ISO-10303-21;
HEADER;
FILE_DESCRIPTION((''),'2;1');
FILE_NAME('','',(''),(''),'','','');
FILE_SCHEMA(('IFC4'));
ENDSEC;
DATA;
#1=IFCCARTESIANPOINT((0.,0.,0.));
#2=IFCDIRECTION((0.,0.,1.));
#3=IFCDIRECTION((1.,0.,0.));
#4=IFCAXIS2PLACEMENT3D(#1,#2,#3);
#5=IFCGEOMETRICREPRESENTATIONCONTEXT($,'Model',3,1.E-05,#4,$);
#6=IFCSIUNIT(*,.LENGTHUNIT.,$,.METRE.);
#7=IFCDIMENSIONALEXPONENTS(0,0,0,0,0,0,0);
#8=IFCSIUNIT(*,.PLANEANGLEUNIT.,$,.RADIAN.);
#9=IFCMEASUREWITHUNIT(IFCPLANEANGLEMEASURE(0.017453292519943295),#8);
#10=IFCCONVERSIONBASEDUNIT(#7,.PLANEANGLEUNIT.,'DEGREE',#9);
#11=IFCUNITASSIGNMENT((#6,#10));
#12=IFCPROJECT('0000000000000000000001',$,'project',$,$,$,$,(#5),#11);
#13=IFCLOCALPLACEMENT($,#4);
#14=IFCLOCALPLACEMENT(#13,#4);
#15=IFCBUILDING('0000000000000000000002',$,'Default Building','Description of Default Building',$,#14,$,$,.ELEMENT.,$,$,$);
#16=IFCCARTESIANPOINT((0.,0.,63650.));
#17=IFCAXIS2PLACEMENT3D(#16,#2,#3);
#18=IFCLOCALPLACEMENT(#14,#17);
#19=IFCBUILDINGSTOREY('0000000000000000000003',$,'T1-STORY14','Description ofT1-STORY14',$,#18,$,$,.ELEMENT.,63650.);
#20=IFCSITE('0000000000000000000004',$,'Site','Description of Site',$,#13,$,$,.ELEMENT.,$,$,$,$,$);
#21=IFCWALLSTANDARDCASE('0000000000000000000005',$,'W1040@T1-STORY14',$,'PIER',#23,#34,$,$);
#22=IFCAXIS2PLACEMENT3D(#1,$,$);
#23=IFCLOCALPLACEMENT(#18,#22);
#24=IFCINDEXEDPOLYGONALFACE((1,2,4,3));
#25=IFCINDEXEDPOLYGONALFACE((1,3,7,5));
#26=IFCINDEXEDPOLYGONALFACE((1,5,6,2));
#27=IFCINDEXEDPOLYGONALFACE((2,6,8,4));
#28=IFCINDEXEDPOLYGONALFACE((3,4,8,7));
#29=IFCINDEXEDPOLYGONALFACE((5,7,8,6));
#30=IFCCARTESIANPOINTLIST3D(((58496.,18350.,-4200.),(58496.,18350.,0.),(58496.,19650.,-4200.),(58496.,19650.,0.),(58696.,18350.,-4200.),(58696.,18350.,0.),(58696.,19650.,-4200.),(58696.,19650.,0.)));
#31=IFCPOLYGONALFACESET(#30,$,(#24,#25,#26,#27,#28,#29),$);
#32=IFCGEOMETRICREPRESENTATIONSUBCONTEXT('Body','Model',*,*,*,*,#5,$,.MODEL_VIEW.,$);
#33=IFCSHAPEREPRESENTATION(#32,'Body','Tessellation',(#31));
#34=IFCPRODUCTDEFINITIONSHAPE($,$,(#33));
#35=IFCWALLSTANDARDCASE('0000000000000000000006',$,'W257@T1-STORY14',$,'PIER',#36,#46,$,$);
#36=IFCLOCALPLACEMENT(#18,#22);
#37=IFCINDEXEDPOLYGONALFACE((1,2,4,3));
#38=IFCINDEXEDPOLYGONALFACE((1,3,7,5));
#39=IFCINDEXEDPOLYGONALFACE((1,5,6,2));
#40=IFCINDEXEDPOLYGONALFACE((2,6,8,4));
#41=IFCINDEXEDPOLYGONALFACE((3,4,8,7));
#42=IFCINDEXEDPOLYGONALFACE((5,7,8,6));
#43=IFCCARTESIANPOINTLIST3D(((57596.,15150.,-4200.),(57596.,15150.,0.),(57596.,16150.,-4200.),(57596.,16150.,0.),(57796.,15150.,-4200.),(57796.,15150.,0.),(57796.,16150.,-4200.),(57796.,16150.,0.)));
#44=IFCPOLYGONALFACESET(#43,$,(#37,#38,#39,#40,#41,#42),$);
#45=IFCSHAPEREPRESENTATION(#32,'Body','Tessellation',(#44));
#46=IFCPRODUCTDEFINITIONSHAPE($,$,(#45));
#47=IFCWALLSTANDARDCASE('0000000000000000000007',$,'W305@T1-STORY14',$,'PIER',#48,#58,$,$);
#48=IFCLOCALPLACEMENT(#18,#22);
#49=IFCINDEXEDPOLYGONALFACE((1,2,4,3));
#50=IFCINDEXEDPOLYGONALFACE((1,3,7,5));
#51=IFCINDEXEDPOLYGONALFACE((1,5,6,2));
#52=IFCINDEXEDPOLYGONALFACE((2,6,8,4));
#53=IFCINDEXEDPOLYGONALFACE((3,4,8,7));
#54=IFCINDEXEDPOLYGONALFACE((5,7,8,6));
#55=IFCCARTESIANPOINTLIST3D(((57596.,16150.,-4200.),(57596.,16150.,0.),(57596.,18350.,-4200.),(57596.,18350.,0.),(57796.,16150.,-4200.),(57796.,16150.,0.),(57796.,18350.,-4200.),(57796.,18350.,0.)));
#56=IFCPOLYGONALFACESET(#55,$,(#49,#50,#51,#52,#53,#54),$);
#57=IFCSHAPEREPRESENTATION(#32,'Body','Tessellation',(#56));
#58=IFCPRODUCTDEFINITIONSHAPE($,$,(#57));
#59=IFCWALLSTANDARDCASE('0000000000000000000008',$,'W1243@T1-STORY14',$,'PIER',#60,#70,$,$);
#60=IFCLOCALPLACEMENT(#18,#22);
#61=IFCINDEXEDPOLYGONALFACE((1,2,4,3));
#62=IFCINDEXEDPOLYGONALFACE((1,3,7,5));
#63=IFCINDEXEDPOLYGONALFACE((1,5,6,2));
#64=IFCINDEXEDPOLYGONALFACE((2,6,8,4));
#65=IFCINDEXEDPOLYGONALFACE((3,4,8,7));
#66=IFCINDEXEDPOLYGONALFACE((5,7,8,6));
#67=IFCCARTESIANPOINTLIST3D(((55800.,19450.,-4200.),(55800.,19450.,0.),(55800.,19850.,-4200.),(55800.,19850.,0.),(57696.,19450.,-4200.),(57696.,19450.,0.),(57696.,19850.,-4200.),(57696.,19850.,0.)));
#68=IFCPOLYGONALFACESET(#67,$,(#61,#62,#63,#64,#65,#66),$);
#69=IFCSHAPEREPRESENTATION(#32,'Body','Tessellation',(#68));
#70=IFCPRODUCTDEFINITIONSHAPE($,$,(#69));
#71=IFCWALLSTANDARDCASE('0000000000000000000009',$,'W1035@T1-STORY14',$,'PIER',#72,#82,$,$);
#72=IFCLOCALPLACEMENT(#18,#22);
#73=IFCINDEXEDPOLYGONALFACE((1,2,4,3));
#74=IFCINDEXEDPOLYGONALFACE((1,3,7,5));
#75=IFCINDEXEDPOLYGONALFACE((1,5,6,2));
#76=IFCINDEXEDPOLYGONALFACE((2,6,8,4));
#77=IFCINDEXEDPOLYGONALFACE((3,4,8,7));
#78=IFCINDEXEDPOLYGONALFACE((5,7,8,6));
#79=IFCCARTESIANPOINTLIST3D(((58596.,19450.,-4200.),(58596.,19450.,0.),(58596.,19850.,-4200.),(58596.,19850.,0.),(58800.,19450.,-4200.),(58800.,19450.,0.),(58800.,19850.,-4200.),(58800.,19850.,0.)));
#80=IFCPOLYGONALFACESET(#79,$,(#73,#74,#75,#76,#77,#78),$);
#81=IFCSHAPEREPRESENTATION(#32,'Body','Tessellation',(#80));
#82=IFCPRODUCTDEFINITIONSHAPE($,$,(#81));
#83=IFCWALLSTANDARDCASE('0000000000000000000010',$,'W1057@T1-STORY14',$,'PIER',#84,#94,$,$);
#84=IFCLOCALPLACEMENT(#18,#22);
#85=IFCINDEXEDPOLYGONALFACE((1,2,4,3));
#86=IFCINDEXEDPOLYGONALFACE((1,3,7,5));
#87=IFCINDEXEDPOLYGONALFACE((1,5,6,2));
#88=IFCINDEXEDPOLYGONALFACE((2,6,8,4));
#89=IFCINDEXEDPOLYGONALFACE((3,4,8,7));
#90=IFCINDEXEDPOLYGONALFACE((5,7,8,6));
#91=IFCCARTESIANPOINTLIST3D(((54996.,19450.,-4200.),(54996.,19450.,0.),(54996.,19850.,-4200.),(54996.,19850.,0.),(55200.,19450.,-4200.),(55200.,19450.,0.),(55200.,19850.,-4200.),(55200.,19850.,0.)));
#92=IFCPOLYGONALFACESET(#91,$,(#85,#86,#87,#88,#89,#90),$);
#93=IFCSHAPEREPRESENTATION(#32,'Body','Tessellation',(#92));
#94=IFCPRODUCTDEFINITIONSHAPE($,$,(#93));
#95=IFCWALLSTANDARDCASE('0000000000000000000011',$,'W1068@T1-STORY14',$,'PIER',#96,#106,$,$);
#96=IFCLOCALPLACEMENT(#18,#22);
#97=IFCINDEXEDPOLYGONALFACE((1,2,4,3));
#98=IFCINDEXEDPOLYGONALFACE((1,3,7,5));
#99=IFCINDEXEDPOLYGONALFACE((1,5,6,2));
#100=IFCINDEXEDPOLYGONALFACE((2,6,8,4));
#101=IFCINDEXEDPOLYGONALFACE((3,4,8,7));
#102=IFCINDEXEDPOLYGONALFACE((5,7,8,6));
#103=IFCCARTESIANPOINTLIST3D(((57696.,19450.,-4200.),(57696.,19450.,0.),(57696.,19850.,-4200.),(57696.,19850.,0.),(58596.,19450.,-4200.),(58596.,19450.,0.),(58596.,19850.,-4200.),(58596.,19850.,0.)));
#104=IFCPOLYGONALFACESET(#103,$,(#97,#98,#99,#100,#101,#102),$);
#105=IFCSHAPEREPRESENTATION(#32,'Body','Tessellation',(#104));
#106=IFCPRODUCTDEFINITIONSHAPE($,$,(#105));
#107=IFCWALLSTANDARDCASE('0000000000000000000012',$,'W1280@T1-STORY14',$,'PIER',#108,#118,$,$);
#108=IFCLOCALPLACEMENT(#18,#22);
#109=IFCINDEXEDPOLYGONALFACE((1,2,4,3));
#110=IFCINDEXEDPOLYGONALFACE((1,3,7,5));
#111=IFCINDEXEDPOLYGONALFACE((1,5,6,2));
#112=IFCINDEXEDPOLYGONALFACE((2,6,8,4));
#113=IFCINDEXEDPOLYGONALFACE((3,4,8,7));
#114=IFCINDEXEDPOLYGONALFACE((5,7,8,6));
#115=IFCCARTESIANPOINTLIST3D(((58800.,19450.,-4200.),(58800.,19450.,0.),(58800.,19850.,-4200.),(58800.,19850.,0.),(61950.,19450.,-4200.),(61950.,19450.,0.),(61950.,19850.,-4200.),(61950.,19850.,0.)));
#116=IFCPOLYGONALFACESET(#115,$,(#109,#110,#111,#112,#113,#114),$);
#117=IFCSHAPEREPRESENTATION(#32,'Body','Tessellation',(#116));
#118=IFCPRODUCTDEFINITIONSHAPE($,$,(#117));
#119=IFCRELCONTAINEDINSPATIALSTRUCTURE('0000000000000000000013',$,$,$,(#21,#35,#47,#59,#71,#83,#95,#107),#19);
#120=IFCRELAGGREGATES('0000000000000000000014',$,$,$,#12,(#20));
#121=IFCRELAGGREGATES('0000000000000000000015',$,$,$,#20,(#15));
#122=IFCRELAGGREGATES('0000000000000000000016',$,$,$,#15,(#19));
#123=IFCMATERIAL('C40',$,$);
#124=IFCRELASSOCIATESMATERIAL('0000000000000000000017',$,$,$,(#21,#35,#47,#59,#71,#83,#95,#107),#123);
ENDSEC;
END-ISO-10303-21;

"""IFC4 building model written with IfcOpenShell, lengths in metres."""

from ifc_helpers import new_model, entity, si_unit, converted_unit, frame, origin_with_axes, place, context, subcontext, project, spatial, indexed_curve, outline, extrude, material, element, save


model = new_model("IFC4")

# Units and contexts
model_context = context("Model", 3, precision=1e-05, world=origin_with_axes())
body_context = subcontext(model_context, "Body", "Model", "MODEL_VIEW")
ifc_project = project(units=[si_unit("LENGTHUNIT", "METRE"), converted_unit("PLANEANGLEUNIT", "DEGREE", entity("IfcPlaneAngleMeasure", 0.017453292519943295), si_unit("PLANEANGLEUNIT", "RADIAN"), dimensions=[0, 0, 0, 0, 0, 0, 0])], contexts=[model_context])

# Site, building, storey
site_placement = place(None, origin_with_axes())
site = spatial("IfcSite", under=ifc_project, at=site_placement, Name="Site", Description="Description of Site", CompositionType="ELEMENT")
building_placement = place(site_placement, origin_with_axes())
building = spatial("IfcBuilding", under=site, at=building_placement, Name="Default Building", Description="Description of Default Building", CompositionType="ELEMENT")
storey_placement = place(building_placement, frame((0.0, 0.0, 63650.0), z_axis=(0.0, 0.0, 1.0), x_axis=(1.0, 0.0, 0.0)))
storey = spatial("IfcBuildingStorey", under=building, at=storey_placement, Name="T1-STORY14", Description="Description ofT1-STORY14", CompositionType="ELEMENT", Elevation=63650.0)

# Shared definitions
ifc_material_1 = material(Name="C40")

# Walls
wall_1_placement = place(storey_placement, frame((58596.0, 18350.0, -4200.0), z_axis=(0.0, 0.0, 1.0), x_axis=(0.0, 1.0, 0.0)))
element("IfcWallStandardCase", 1, at=wall_1_placement, inside=storey, material=ifc_material_1, Name="W1040@T1-STORY14", ObjectType="PIER", context=body_context, shape_type="SweptSolid", body=[
    extrude(outline(indexed_curve([(0.0, -100.0), (0.0, 100.0), (1300.0, 100.0), (1300.0, -100.0), (0.0, -100.0)], self_intersect=False)), origin_with_axes(), (0.0, 0.0, 1.0), 4200.0),
])
wall_2_placement = place(storey_placement, frame((57696.0, 15150.0, -4200.0), z_axis=(0.0, 0.0, 1.0), x_axis=(0.0, 1.0, 0.0)))
element("IfcWallStandardCase", 2, at=wall_2_placement, inside=storey, material=ifc_material_1, Name="W257@T1-STORY14", ObjectType="PIER", context=body_context, shape_type="SweptSolid", body=[
    extrude(outline(indexed_curve([(0.0, -100.0), (0.0, 100.0), (1000.0, 100.0), (1000.0, -100.0), (0.0, -100.0)], self_intersect=False)), origin_with_axes(), (0.0, 0.0, 1.0), 4200.0),
])
wall_3_placement = place(storey_placement, frame((57696.0, 16150.0, -4200.0), z_axis=(0.0, 0.0, 1.0), x_axis=(0.0, 1.0, 0.0)))
element("IfcWallStandardCase", 3, at=wall_3_placement, inside=storey, material=ifc_material_1, Name="W305@T1-STORY14", ObjectType="PIER", context=body_context, shape_type="SweptSolid", body=[
    extrude(outline(indexed_curve([(0.0, -100.0), (0.0, 100.0), (2200.0, 100.0), (2200.0, -100.0), (0.0, -100.0)], self_intersect=False)), origin_with_axes(), (0.0, 0.0, 1.0), 4200.0),
])
wall_4_placement = place(storey_placement, frame((55800.0, 19650.0, -4200.0), z_axis=(0.0, 0.0, 1.0), x_axis=(1.0, 0.0, 0.0)))
element("IfcWallStandardCase", 4, at=wall_4_placement, inside=storey, material=ifc_material_1, Name="W1243@T1-STORY14", ObjectType="PIER", context=body_context, shape_type="SweptSolid", body=[
    extrude(outline(indexed_curve([(0.0, -200.0), (0.0, 200.0), (1896.0, 200.0), (1896.0, -200.0), (0.0, -200.0)], self_intersect=False)), origin_with_axes(), (0.0, 0.0, 1.0), 4200.0),
])
for number, where, z_axis, x_axis, name in (
    (5, (58596.0, 19650.0, -4200.0), (0.0, 0.0, 1.0), (1.0, 0.0, 0.0), "W1035@T1-STORY14"),
    (6, (54996.0, 19650.0, -4200.0), (0.0, 0.0, 1.0), (1.0, 0.0, 0.0), "W1057@T1-STORY14"),
):
    element("IfcWallStandardCase", number, at=place(storey_placement, frame(where, z_axis=z_axis, x_axis=x_axis)), inside=storey, material=ifc_material_1, Name=name, ObjectType="PIER", context=body_context, shape_type="SweptSolid", body=[
        extrude(outline(indexed_curve([(0.0, -200.0), (0.0, 200.0), (204.0, 200.0), (204.0, -200.0), (0.0, -200.0)], self_intersect=False)), origin_with_axes(), (0.0, 0.0, 1.0), 4200.0),
    ])
wall_5_placement = place(storey_placement, frame((57696.0, 19650.0, -4200.0), z_axis=(0.0, 0.0, 1.0), x_axis=(1.0, 0.0, 0.0)))
element("IfcWallStandardCase", 7, at=wall_5_placement, inside=storey, material=ifc_material_1, Name="W1068@T1-STORY14", ObjectType="PIER", context=body_context, shape_type="SweptSolid", body=[
    extrude(outline(indexed_curve([(0.0, -200.0), (0.0, 200.0), (900.0, 200.0), (900.0, -200.0), (0.0, -200.0)], self_intersect=False)), origin_with_axes(), (0.0, 0.0, 1.0), 4200.0),
])
wall_6_placement = place(storey_placement, frame((58800.0, 19650.0, -4200.0), z_axis=(0.0, 0.0, 1.0), x_axis=(1.0, 0.0, 0.0)))
element("IfcWallStandardCase", 8, at=wall_6_placement, inside=storey, material=ifc_material_1, Name="W1280@T1-STORY14", ObjectType="PIER", context=body_context, shape_type="SweptSolid", body=[
    extrude(outline(indexed_curve([(0.0, -200.0), (0.0, 200.0), (3150.0, 200.0), (3150.0, -200.0), (0.0, -200.0)], self_intersect=False)), origin_with_axes(), (0.0, 0.0, 1.0), 4200.0),
])

save(model, "model.ifc")
